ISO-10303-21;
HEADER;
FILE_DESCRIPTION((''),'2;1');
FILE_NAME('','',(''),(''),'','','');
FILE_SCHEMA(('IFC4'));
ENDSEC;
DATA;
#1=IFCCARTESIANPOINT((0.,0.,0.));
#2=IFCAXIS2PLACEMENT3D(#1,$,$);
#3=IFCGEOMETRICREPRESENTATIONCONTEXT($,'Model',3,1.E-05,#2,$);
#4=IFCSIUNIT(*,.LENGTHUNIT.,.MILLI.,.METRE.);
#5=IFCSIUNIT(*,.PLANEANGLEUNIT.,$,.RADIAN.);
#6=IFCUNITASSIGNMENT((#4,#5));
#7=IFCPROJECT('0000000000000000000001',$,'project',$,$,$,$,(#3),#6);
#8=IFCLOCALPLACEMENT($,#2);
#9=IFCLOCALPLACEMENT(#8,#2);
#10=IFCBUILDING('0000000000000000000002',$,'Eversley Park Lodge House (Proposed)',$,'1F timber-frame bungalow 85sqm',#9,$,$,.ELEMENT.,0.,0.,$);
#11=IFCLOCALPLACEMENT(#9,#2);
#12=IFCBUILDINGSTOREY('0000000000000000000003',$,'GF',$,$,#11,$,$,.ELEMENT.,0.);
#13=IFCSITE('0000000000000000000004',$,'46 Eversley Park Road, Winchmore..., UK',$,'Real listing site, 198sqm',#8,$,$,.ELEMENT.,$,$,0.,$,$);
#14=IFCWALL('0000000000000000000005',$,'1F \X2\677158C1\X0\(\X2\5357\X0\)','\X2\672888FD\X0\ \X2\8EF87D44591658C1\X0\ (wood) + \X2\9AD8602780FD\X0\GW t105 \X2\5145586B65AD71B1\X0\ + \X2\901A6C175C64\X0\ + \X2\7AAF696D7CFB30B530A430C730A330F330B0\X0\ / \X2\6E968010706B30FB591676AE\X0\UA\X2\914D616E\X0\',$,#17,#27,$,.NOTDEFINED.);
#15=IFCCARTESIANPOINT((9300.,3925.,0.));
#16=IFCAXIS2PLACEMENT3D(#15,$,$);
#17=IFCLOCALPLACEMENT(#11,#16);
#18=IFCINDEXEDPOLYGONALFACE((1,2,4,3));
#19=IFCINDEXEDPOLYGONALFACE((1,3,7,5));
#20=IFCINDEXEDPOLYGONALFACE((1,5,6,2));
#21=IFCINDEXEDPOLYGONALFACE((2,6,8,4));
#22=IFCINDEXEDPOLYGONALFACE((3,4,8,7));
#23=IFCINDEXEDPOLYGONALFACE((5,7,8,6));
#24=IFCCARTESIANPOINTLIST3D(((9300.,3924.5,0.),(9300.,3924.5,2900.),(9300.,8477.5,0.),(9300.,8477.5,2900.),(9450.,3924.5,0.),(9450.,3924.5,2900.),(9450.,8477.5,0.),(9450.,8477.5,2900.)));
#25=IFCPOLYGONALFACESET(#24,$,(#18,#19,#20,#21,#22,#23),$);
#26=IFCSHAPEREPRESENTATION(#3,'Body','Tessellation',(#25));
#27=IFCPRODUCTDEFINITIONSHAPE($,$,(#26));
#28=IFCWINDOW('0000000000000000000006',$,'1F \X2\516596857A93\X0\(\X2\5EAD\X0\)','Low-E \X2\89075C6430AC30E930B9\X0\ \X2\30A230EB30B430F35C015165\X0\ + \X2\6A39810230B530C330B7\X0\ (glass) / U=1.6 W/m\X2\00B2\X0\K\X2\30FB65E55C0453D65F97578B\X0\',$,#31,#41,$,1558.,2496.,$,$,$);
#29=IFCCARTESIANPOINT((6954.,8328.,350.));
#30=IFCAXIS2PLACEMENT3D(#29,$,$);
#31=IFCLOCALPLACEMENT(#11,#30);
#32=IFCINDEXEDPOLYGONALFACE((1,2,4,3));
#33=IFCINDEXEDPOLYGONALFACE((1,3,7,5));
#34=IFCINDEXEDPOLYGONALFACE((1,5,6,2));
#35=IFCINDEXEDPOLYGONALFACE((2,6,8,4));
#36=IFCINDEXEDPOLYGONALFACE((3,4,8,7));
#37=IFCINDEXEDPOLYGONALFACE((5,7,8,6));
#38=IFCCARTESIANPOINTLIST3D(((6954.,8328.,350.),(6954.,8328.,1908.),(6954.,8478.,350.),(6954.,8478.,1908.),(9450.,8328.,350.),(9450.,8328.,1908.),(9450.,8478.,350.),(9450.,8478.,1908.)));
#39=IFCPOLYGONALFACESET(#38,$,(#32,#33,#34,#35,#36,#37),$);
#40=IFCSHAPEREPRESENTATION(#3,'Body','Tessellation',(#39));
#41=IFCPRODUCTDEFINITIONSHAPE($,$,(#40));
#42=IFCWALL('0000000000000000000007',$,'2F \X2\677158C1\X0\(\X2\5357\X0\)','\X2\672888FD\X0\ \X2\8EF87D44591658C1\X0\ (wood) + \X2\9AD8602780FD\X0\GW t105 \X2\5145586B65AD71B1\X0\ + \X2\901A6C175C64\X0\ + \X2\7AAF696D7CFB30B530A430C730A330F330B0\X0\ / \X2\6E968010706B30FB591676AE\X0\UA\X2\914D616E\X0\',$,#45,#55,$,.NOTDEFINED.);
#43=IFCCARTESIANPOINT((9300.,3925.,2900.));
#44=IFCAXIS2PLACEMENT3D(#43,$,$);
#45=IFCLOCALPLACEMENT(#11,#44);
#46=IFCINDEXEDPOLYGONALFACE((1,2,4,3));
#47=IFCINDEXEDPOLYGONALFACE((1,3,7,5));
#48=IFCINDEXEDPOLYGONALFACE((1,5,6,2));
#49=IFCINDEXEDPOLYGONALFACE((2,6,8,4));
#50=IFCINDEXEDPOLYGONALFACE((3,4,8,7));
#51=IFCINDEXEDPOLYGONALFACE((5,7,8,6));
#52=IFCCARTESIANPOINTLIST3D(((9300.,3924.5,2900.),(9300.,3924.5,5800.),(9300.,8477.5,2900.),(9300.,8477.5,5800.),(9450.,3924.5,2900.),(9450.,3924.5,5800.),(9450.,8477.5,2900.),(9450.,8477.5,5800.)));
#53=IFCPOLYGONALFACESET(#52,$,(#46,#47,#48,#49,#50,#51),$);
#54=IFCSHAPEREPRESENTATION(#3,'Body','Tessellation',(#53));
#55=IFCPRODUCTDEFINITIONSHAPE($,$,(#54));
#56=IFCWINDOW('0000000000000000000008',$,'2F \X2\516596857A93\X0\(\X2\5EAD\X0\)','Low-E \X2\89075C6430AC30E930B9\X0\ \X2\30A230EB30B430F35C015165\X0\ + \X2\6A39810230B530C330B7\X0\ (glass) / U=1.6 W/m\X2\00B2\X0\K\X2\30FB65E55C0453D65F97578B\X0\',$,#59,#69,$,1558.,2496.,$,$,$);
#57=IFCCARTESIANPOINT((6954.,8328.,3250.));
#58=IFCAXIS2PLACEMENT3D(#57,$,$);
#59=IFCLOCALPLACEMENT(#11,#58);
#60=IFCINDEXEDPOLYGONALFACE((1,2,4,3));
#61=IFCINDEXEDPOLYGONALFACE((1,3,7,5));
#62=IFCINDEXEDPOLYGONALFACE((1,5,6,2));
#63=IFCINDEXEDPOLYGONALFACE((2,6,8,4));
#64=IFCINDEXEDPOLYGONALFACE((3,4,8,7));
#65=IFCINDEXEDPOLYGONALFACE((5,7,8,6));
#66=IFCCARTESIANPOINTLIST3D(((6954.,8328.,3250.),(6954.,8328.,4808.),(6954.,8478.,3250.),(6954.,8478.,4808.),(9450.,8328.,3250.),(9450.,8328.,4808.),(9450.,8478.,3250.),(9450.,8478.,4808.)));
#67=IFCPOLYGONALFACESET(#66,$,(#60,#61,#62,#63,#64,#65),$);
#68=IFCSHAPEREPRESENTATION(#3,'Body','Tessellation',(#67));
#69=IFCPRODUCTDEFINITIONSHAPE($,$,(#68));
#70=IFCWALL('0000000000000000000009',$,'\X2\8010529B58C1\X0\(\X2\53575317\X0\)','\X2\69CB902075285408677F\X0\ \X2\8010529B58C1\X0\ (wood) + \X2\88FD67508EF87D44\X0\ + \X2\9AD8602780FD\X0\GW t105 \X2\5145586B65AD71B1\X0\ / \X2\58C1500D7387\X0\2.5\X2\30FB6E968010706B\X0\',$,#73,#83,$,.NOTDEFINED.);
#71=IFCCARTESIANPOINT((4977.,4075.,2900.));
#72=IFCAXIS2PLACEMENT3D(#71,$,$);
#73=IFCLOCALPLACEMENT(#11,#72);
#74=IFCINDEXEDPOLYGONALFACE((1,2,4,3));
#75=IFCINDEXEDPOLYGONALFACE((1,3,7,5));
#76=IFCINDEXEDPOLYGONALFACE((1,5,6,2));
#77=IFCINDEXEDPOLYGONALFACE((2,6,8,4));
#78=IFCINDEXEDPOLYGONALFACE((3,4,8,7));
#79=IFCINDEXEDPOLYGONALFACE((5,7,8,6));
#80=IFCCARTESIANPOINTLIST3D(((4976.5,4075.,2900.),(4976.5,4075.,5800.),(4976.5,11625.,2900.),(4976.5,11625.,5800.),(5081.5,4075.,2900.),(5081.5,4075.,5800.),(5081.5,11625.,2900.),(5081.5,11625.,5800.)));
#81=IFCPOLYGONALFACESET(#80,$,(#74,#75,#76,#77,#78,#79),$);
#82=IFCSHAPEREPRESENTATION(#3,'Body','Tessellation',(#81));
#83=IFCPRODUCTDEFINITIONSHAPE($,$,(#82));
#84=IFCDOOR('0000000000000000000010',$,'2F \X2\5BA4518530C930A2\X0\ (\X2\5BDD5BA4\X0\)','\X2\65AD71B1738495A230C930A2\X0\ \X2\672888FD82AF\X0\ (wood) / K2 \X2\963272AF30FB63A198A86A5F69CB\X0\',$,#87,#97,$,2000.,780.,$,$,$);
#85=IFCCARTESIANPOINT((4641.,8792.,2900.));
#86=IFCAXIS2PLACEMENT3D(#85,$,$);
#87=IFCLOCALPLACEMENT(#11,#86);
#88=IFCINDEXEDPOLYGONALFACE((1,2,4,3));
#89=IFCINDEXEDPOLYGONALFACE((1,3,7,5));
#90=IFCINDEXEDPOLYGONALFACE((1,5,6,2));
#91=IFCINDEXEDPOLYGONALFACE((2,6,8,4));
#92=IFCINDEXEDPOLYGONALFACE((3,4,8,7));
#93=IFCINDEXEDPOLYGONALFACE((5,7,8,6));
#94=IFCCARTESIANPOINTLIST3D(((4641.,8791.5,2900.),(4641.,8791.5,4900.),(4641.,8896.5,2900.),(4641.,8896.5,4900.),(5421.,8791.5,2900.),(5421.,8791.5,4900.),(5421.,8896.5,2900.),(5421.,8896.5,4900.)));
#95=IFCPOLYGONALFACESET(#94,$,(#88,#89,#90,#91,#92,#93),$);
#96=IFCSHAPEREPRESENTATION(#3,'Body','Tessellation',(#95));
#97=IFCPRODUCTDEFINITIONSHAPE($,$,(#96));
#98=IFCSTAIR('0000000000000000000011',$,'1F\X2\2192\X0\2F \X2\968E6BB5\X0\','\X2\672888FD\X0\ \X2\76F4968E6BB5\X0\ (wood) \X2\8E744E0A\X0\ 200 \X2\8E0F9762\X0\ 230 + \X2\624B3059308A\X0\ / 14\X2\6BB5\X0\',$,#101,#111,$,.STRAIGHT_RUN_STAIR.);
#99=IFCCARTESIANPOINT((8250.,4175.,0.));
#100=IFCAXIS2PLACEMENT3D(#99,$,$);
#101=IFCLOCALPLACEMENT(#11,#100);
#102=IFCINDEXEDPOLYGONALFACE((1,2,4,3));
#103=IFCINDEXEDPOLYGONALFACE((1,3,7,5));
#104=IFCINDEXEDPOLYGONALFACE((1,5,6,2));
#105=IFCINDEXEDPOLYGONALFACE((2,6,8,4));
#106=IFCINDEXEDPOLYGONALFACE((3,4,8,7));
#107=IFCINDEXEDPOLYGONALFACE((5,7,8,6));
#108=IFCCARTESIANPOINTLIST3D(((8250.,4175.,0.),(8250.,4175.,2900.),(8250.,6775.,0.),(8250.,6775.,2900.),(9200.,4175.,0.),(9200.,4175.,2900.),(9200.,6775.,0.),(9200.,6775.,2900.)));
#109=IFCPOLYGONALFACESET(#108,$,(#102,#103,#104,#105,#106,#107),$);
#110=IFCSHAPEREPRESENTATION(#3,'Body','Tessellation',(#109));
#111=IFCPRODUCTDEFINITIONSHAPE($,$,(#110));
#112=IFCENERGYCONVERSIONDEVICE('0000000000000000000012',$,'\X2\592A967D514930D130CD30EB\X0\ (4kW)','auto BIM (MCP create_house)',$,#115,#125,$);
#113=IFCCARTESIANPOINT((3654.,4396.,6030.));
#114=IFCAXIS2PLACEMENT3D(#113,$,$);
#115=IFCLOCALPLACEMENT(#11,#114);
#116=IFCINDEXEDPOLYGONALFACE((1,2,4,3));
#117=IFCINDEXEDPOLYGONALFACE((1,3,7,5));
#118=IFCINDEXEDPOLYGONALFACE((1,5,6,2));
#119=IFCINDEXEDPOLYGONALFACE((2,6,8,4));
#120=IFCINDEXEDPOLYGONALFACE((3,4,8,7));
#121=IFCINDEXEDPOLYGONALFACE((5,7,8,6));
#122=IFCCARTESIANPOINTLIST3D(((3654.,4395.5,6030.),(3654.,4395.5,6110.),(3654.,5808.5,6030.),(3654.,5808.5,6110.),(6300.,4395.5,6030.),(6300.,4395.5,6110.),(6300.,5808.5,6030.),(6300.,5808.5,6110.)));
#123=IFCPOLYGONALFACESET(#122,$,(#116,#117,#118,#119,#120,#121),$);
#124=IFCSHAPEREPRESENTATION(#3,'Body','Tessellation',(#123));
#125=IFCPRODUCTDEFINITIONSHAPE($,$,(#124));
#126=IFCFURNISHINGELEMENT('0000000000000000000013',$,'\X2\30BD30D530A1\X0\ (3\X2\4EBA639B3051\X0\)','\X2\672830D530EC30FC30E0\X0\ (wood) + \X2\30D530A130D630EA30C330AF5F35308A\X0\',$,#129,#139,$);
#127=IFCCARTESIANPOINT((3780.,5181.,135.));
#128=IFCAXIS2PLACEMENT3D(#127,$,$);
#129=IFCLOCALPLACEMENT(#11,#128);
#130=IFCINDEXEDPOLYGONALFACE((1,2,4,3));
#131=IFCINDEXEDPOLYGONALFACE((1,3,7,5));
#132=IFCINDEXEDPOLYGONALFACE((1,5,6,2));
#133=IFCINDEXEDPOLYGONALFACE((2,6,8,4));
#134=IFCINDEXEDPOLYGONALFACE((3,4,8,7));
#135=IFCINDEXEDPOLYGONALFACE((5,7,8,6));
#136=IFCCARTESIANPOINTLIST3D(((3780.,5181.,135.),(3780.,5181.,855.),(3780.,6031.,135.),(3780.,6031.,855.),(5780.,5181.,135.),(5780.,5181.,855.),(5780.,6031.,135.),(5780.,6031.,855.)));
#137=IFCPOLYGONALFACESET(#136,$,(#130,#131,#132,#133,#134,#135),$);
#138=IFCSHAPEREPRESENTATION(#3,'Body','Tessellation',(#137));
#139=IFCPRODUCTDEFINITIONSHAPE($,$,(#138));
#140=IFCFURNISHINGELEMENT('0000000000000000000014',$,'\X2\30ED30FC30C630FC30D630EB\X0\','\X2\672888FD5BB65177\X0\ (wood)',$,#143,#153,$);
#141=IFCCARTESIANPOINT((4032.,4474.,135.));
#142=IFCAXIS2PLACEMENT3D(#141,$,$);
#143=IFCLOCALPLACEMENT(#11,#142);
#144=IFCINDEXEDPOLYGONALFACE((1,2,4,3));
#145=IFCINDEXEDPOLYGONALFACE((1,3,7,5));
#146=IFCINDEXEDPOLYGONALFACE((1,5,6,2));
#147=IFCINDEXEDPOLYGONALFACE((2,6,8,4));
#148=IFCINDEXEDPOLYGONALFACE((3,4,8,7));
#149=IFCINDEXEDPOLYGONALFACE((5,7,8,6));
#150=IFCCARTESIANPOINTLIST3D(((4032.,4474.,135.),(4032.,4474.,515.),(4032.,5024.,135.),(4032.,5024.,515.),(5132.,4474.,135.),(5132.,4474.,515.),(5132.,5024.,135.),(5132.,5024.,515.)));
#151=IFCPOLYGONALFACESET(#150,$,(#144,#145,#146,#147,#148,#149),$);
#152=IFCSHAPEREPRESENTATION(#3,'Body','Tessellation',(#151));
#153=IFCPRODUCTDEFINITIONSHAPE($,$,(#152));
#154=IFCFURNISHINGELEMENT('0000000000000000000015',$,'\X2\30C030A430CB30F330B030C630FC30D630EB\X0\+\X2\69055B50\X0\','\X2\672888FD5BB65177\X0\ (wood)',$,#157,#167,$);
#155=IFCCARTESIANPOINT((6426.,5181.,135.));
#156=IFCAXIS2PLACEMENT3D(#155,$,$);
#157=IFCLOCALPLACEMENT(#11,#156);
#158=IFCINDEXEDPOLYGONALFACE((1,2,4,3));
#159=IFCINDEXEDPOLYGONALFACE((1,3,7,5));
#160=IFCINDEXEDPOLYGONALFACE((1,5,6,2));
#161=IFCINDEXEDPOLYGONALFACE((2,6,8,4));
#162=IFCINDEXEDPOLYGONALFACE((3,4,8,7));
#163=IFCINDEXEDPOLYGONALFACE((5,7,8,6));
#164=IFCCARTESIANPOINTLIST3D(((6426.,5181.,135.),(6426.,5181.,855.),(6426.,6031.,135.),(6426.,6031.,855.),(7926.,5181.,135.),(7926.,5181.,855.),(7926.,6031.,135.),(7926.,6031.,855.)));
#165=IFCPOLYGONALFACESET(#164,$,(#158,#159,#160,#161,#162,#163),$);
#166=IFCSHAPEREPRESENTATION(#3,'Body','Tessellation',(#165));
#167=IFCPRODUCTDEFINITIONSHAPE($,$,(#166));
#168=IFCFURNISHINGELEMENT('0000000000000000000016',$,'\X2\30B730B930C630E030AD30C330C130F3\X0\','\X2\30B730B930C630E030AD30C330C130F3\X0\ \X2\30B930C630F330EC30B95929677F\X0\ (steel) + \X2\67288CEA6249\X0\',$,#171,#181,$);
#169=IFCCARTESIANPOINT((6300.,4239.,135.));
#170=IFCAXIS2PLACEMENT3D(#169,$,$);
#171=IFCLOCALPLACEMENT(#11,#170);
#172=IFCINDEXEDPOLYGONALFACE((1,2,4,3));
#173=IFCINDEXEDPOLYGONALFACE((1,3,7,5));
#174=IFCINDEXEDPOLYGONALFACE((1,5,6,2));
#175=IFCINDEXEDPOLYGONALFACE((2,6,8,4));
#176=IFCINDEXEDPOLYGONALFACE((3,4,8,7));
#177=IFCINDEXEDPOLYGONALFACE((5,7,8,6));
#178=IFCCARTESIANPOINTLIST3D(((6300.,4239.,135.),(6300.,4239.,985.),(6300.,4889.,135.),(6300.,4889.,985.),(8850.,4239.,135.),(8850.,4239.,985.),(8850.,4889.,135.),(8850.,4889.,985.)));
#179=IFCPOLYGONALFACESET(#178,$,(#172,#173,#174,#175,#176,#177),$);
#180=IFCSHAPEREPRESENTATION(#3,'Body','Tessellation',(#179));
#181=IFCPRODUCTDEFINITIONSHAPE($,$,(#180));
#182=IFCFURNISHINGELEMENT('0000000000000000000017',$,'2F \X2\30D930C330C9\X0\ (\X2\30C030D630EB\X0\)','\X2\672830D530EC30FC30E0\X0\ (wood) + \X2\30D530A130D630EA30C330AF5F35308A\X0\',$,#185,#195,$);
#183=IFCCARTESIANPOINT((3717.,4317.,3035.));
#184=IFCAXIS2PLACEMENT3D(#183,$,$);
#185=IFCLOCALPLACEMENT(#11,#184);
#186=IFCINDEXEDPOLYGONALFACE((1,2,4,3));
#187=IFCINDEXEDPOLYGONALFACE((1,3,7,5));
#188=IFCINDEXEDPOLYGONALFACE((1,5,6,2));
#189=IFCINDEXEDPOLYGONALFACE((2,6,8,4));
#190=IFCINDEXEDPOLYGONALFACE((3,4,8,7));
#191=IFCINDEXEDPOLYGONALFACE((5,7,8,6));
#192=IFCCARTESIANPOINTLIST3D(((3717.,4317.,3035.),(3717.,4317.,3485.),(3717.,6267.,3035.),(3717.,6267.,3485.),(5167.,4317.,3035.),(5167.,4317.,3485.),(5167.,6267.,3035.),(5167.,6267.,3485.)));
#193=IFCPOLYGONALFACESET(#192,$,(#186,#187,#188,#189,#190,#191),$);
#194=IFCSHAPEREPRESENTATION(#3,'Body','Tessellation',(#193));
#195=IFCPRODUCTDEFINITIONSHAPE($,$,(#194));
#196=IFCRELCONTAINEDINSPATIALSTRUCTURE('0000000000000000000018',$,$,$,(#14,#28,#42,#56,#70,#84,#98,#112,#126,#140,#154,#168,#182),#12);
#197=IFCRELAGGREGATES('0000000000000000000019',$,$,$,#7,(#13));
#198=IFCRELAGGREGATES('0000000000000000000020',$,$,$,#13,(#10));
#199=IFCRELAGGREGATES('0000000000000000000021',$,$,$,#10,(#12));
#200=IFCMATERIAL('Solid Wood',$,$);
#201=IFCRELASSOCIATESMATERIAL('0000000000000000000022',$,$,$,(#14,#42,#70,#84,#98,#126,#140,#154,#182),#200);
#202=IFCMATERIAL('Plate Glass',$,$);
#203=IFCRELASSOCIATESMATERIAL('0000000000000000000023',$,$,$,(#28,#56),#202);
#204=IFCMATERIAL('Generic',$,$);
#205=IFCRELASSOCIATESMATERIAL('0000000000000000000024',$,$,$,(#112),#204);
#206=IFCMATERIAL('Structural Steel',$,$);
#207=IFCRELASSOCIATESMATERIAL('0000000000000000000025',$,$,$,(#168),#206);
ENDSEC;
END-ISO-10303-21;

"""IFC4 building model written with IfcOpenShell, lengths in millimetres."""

from ifc_helpers import new_model, si_unit, frame, frame_2d, origin, place, context, project, spatial, rectangle, extrude, material, element, fill, save


model = new_model("IFC4")

# Units and contexts
model_context = context("Model", 3, precision=1e-05, world=origin())
ifc_project = project(units=[si_unit("LENGTHUNIT", "METRE", prefix="MILLI"), si_unit("PLANEANGLEUNIT", "RADIAN")], contexts=[model_context])

# Site, building, storey
site_placement = place(None, origin())
site = spatial("IfcSite", under=ifc_project, at=site_placement, Name="46 Eversley Park Road, Winchmore..., UK", ObjectType="Real listing site, 198sqm", CompositionType="ELEMENT", RefElevation=0.0)
building_placement = place(site_placement, origin())
building = spatial("IfcBuilding", under=site, at=building_placement, Name="Eversley Park Lodge House (Proposed)", ObjectType="1F timber-frame bungalow 85sqm", CompositionType="ELEMENT", ElevationOfRefHeight=0.0, ElevationOfTerrain=0.0)
storey_placement = place(building_placement, origin())
storey = spatial("IfcBuildingStorey", under=building, at=storey_placement, Name="GF", CompositionType="ELEMENT", Elevation=0.0)

# Wall, opening, window
ifc_material_1 = material(Name="Solid Wood")
wall_1_placement = place(storey_placement, frame((9300.0, 3925.0, 0.0)))
wall_1 = element("IfcWall", 1, at=wall_1_placement, inside=storey, material=ifc_material_1, Name="1F 東壁(南)", Description="木製 軸組外壁 (wood) + 高性能GW t105 充填断熱 + 通気層 + 窯業系サイディング / 準耐火・外皮UA配慮", PredefinedType="NOTDEFINED", context=model_context, shape_type="SweptSolid", body=[
    extrude(rectangle(XDim=150.0, YDim=4553.0, at=frame_2d((75.0, 2276.0))), frame((9300.0, 3925.0, 0.0)), (0.0, 0.0, 1.0), 2900.0),
])
opening_1_placement = place(storey_placement, frame((6954.0, 8328.0, 350.0)))
opening_1 = element("IfcOpeningElement", 2, at=opening_1_placement, cuts=wall_1, PredefinedType="NOTDEFINED", context=model_context, shape_type="SweptSolid", body=[
    extrude(rectangle(XDim=2496.0, YDim=150.0, at=frame_2d((1248.0, 75.0))), frame((6954.0, 8328.0, 350.0)), (0.0, 0.0, 1.0), 1558.0),
])
ifc_material_2 = material(Name="Plate Glass")
window_1_placement = place(storey_placement, frame((6954.0, 8328.0, 350.0)))
window_1 = element("IfcWindow", 3, at=window_1_placement, inside=storey, material=ifc_material_2, Name="1F 入隅窓(庭)", Description="Low-E 複層ガラス アルゴン封入 + 樹脂サッシ (glass) / U=1.6 W/m²K・日射取得型", OverallHeight=1558.0, OverallWidth=2496.0, context=model_context, shape_type="SweptSolid", body=[
    extrude(rectangle(XDim=2496.0, YDim=150.0, at=frame_2d((1248.0, 75.0))), frame((6954.0, 8328.0, 350.0)), (0.0, 0.0, 1.0), 1558.0),
])
fill(opening_1, window_1)

# Wall, opening, window
wall_2_placement = place(storey_placement, frame((9300.0, 3925.0, 2900.0)))
wall_2 = element("IfcWall", 4, at=wall_2_placement, inside=storey, material=ifc_material_1, Name="2F 東壁(南)", Description="木製 軸組外壁 (wood) + 高性能GW t105 充填断熱 + 通気層 + 窯業系サイディング / 準耐火・外皮UA配慮", PredefinedType="NOTDEFINED", context=model_context, shape_type="SweptSolid", body=[
    extrude(rectangle(XDim=150.0, YDim=4553.0, at=frame_2d((75.0, 2276.0))), frame((9300.0, 3925.0, 2900.0)), (0.0, 0.0, 1.0), 2900.0),
])
opening_2_placement = place(storey_placement, frame((6954.0, 8328.0, 3250.0)))
opening_2 = element("IfcOpeningElement", 5, at=opening_2_placement, cuts=wall_2, PredefinedType="NOTDEFINED", context=model_context, shape_type="SweptSolid", body=[
    extrude(rectangle(XDim=2496.0, YDim=150.0, at=frame_2d((1248.0, 75.0))), frame((6954.0, 8328.0, 3250.0)), (0.0, 0.0, 1.0), 1558.0),
])
window_2_placement = place(storey_placement, frame((6954.0, 8328.0, 3250.0)))
window_2 = element("IfcWindow", 6, at=window_2_placement, inside=storey, material=ifc_material_2, Name="2F 入隅窓(庭)", Description="Low-E 複層ガラス アルゴン封入 + 樹脂サッシ (glass) / U=1.6 W/m²K・日射取得型", OverallHeight=1558.0, OverallWidth=2496.0, context=model_context, shape_type="SweptSolid", body=[
    extrude(rectangle(XDim=2496.0, YDim=150.0, at=frame_2d((1248.0, 75.0))), frame((6954.0, 8328.0, 3250.0)), (0.0, 0.0, 1.0), 1558.0),
])
fill(opening_2, window_2)

# Wall, opening, door
wall_3_placement = place(storey_placement, frame((4977.0, 4075.0, 2900.0)))
wall_3 = element("IfcWall", 7, at=wall_3_placement, inside=storey, material=ifc_material_1, Name="耐力壁(南北)", Description="構造用合板 耐力壁 (wood) + 製材軸組 + 高性能GW t105 充填断熱 / 壁倍率2.5・準耐火", PredefinedType="NOTDEFINED", context=model_context, shape_type="SweptSolid", body=[
    extrude(rectangle(XDim=105.0, YDim=7550.0, at=frame_2d((52.0, 3775.0))), frame((4977.0, 4075.0, 2900.0)), (0.0, 0.0, 1.0), 2900.0),
])
opening_3_placement = place(storey_placement, frame((4641.0, 8792.0, 2900.0)))
opening_3 = element("IfcOpeningElement", 8, at=opening_3_placement, cuts=wall_3, PredefinedType="NOTDEFINED", context=model_context, shape_type="SweptSolid", body=[
    extrude(rectangle(XDim=780.0, YDim=105.0, at=frame_2d((390.0, 52.0))), frame((4641.0, 8792.0, 2900.0)), (0.0, 0.0, 1.0), 2000.0),
])
door_1_placement = place(storey_placement, frame((4641.0, 8792.0, 2900.0)))
door_1 = element("IfcDoor", 9, at=door_1_placement, inside=storey, material=ifc_material_1, Name="2F 室内ドア (寝室)", Description="断熱玄関ドア 木製芯 (wood) / K2 防犯・採風機構", OverallHeight=2000.0, OverallWidth=780.0, context=model_context, shape_type="SweptSolid", body=[
    extrude(rectangle(XDim=780.0, YDim=105.0, at=frame_2d((390.0, 52.0))), frame((4641.0, 8792.0, 2900.0)), (0.0, 0.0, 1.0), 2000.0),
])
fill(opening_3, door_1)

# Stair
stair_placement = place(storey_placement, frame((8250.0, 4175.0, 0.0)))
element("IfcStair", 10, at=stair_placement, inside=storey, material=ifc_material_1, Name="1F→2F 階段", Description="木製 直階段 (wood) 蹴上 200 踏面 230 + 手すり / 14段", PredefinedType="STRAIGHT_RUN_STAIR", context=model_context, shape_type="SweptSolid", body=[
    extrude(rectangle(XDim=950.0, YDim=2600.0, at=frame_2d((475.0, 1300.0))), frame((8250.0, 4175.0, 0.0)), (0.0, 0.0, 1.0), 2900.0),
])

# Energy conversion device
ifc_material_3 = material(Name="Generic")
energy_conversion_device_placement = place(storey_placement, frame((3654.0, 4396.0, 6030.0)))
element("IfcEnergyConversionDevice", 11, at=energy_conversion_device_placement, inside=storey, material=ifc_material_3, Name="太陽光パネル (4kW)", Description="auto BIM (MCP create_house)", context=model_context, shape_type="SweptSolid", body=[
    extrude(rectangle(XDim=2646.0, YDim=1413.0, at=frame_2d((1323.0, 706.0))), frame((3654.0, 4396.0, 6030.0)), (0.0, 0.0, 1.0), 80.0),
])

# Furnishing elements
furnishing_1_placement = place(storey_placement, frame((3780.0, 5181.0, 135.0)))
element("IfcFurnishingElement", 12, at=furnishing_1_placement, inside=storey, material=ifc_material_1, Name="ソファ (3人掛け)", Description="木フレーム (wood) + ファブリック張り", context=model_context, shape_type="SweptSolid", body=[
    extrude(rectangle(XDim=2000.0, YDim=850.0, at=frame_2d((1000.0, 425.0))), frame((3780.0, 5181.0, 135.0)), (0.0, 0.0, 1.0), 720.0),
])
furnishing_2_placement = place(storey_placement, frame((4032.0, 4474.0, 135.0)))
element("IfcFurnishingElement", 13, at=furnishing_2_placement, inside=storey, material=ifc_material_1, Name="ローテーブル", Description="木製家具 (wood)", context=model_context, shape_type="SweptSolid", body=[
    extrude(rectangle(XDim=1100.0, YDim=550.0, at=frame_2d((550.0, 275.0))), frame((4032.0, 4474.0, 135.0)), (0.0, 0.0, 1.0), 380.0),
])
furnishing_3_placement = place(storey_placement, frame((6426.0, 5181.0, 135.0)))
element("IfcFurnishingElement", 14, at=furnishing_3_placement, inside=storey, material=ifc_material_1, Name="ダイニングテーブル+椅子", Description="木製家具 (wood)", context=model_context, shape_type="SweptSolid", body=[
    extrude(rectangle(XDim=1500.0, YDim=850.0, at=frame_2d((750.0, 425.0))), frame((6426.0, 5181.0, 135.0)), (0.0, 0.0, 1.0), 720.0),
])
ifc_material_4 = material(Name="Structural Steel")
furnishing_4_placement = place(storey_placement, frame((6300.0, 4239.0, 135.0)))
element("IfcFurnishingElement", 15, at=furnishing_4_placement, inside=storey, material=ifc_material_4, Name="システムキッチン", Description="システムキッチン ステンレス天板 (steel) + 木質扉", context=model_context, shape_type="SweptSolid", body=[
    extrude(rectangle(XDim=2550.0, YDim=650.0, at=frame_2d((1275.0, 325.0))), frame((6300.0, 4239.0, 135.0)), (0.0, 0.0, 1.0), 850.0),
])
furnishing_5_placement = place(storey_placement, frame((3717.0, 4317.0, 3035.0)))
element("IfcFurnishingElement", 16, at=furnishing_5_placement, inside=storey, material=ifc_material_1, Name="2F ベッド (ダブル)", Description="木フレーム (wood) + ファブリック張り", context=model_context, shape_type="SweptSolid", body=[
    extrude(rectangle(XDim=1450.0, YDim=1950.0, at=frame_2d((725.0, 975.0))), frame((3717.0, 4317.0, 3035.0)), (0.0, 0.0, 1.0), 450.0),
])

save(model, "model.ifc")
